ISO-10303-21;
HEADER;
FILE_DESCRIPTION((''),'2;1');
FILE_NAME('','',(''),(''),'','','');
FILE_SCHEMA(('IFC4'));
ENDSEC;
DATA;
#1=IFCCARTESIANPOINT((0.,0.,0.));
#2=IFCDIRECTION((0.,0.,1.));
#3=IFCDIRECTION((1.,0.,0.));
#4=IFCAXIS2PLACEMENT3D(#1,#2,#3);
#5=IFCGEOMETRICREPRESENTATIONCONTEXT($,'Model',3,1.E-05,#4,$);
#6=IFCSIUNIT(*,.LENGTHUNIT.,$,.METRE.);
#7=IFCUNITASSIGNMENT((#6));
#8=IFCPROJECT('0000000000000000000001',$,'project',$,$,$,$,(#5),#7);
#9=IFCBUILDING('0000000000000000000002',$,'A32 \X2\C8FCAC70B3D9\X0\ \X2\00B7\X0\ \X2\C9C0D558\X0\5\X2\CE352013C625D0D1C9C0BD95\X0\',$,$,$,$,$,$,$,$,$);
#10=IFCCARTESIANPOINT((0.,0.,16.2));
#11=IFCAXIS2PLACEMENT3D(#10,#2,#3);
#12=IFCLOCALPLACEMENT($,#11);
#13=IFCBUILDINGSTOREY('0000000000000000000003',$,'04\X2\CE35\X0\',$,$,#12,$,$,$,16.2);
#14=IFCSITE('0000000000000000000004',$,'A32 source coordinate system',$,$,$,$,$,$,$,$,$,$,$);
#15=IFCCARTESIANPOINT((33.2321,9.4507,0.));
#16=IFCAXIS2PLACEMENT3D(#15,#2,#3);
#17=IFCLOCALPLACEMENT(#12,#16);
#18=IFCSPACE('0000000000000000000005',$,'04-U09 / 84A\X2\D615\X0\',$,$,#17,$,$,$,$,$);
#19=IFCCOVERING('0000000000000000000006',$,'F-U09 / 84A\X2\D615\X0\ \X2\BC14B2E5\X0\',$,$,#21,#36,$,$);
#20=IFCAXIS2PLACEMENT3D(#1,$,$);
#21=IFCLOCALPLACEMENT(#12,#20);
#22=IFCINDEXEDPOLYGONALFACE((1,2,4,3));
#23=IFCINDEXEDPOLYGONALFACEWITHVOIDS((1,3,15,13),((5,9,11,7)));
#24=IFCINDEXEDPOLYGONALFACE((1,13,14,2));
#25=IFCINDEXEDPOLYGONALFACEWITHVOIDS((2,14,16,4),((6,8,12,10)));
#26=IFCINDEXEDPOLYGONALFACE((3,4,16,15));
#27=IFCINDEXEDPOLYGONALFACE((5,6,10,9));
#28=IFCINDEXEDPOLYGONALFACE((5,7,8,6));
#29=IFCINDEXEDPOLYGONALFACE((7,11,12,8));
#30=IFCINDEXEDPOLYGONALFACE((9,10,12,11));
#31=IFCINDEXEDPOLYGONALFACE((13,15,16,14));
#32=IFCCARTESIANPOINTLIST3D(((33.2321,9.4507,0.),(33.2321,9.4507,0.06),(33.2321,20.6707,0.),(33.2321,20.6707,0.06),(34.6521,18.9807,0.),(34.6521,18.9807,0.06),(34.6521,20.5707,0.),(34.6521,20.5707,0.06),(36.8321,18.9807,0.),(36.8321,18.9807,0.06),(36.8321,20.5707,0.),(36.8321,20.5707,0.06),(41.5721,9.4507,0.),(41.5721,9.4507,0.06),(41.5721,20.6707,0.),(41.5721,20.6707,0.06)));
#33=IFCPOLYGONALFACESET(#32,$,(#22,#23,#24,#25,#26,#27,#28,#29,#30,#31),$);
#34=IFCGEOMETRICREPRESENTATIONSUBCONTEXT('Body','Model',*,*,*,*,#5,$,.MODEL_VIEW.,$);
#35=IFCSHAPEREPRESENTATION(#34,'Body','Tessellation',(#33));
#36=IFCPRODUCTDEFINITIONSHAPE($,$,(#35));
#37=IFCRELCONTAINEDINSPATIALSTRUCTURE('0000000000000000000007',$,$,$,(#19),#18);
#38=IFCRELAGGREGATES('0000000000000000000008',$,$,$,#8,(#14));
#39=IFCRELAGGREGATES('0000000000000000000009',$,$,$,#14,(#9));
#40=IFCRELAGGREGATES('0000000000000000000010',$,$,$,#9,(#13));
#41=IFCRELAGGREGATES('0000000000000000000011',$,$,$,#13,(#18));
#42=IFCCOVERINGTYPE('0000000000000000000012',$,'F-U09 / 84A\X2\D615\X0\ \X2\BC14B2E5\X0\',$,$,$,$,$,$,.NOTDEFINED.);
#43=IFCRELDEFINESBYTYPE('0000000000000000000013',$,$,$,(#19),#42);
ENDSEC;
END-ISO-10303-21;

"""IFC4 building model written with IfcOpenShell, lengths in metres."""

from ifc_helpers import new_model, si_unit, frame, origin, origin_with_axes, place, context, subcontext, project, spatial, polyline, outline, extrude, source, transform, mapped, type_object, type_shapes, element, save


model = new_model("IFC4")

# Units and contexts
model_context = context("Model", 3, precision=1e-05, world=origin_with_axes())
body_context = subcontext(model_context, "Body", "Model", "MODEL_VIEW")
ifc_project = project(units=[si_unit("LENGTHUNIT", "METRE")], contexts=[model_context])

# Site, building, storey, space
site = spatial("IfcSite", under=ifc_project, Name="A32 source coordinate system")
building = spatial("IfcBuilding", under=site, Name="A32 주거동 · 지하5층–옥탑지붕")
storey_placement = place(None, frame((0.0, 0.0, 16.2), z_axis=(0.0, 0.0, 1.0), x_axis=(1.0, 0.0, 0.0)))
storey = spatial("IfcBuildingStorey", under=building, at=storey_placement, Name="04층", Elevation=16.2)
space_1_placement = place(storey_placement, frame((33.2321, 9.4507, 0.0), z_axis=(0.0, 0.0, 1.0), x_axis=(1.0, 0.0, 0.0)))
space_1 = spatial("IfcSpace", under=storey, at=space_1_placement, Name="04-U09 / 84A형")

# Covering
covering_type_1 = type_object("IfcCoveringType", Name="F-U09 / 84A형 바닥", PredefinedType="NOTDEFINED")
shared_shape_1 = source(origin(), body_context, "Body", "SweptSolid", [
    extrude(outline(polyline([(0.0, 0.0), (0.0, 11.22), (8.34, 11.22), (8.34, 0.0), (0.0, 0.0)]), holes=[polyline([(1.42, 11.12), (1.42, 9.53), (3.6, 9.53), (3.6, 11.12), (1.42, 11.12)])]), origin(), (0.0, 0.0, 1.0), 0.06),
])
type_shapes(covering_type_1, [shared_shape_1])
covering_1_placement = place(space_1_placement, origin_with_axes())
element("IfcCovering", 1, at=covering_1_placement, inside=space_1, type_object=covering_type_1, Name="F-U09 / 84A형 바닥", context=body_context, shape_type="MappedRepresentation", body=[
    mapped(shared_shape_1, transform((0.0, 0.0, 0.0), scale=1.0)),
])

save(model, "model.ifc")
